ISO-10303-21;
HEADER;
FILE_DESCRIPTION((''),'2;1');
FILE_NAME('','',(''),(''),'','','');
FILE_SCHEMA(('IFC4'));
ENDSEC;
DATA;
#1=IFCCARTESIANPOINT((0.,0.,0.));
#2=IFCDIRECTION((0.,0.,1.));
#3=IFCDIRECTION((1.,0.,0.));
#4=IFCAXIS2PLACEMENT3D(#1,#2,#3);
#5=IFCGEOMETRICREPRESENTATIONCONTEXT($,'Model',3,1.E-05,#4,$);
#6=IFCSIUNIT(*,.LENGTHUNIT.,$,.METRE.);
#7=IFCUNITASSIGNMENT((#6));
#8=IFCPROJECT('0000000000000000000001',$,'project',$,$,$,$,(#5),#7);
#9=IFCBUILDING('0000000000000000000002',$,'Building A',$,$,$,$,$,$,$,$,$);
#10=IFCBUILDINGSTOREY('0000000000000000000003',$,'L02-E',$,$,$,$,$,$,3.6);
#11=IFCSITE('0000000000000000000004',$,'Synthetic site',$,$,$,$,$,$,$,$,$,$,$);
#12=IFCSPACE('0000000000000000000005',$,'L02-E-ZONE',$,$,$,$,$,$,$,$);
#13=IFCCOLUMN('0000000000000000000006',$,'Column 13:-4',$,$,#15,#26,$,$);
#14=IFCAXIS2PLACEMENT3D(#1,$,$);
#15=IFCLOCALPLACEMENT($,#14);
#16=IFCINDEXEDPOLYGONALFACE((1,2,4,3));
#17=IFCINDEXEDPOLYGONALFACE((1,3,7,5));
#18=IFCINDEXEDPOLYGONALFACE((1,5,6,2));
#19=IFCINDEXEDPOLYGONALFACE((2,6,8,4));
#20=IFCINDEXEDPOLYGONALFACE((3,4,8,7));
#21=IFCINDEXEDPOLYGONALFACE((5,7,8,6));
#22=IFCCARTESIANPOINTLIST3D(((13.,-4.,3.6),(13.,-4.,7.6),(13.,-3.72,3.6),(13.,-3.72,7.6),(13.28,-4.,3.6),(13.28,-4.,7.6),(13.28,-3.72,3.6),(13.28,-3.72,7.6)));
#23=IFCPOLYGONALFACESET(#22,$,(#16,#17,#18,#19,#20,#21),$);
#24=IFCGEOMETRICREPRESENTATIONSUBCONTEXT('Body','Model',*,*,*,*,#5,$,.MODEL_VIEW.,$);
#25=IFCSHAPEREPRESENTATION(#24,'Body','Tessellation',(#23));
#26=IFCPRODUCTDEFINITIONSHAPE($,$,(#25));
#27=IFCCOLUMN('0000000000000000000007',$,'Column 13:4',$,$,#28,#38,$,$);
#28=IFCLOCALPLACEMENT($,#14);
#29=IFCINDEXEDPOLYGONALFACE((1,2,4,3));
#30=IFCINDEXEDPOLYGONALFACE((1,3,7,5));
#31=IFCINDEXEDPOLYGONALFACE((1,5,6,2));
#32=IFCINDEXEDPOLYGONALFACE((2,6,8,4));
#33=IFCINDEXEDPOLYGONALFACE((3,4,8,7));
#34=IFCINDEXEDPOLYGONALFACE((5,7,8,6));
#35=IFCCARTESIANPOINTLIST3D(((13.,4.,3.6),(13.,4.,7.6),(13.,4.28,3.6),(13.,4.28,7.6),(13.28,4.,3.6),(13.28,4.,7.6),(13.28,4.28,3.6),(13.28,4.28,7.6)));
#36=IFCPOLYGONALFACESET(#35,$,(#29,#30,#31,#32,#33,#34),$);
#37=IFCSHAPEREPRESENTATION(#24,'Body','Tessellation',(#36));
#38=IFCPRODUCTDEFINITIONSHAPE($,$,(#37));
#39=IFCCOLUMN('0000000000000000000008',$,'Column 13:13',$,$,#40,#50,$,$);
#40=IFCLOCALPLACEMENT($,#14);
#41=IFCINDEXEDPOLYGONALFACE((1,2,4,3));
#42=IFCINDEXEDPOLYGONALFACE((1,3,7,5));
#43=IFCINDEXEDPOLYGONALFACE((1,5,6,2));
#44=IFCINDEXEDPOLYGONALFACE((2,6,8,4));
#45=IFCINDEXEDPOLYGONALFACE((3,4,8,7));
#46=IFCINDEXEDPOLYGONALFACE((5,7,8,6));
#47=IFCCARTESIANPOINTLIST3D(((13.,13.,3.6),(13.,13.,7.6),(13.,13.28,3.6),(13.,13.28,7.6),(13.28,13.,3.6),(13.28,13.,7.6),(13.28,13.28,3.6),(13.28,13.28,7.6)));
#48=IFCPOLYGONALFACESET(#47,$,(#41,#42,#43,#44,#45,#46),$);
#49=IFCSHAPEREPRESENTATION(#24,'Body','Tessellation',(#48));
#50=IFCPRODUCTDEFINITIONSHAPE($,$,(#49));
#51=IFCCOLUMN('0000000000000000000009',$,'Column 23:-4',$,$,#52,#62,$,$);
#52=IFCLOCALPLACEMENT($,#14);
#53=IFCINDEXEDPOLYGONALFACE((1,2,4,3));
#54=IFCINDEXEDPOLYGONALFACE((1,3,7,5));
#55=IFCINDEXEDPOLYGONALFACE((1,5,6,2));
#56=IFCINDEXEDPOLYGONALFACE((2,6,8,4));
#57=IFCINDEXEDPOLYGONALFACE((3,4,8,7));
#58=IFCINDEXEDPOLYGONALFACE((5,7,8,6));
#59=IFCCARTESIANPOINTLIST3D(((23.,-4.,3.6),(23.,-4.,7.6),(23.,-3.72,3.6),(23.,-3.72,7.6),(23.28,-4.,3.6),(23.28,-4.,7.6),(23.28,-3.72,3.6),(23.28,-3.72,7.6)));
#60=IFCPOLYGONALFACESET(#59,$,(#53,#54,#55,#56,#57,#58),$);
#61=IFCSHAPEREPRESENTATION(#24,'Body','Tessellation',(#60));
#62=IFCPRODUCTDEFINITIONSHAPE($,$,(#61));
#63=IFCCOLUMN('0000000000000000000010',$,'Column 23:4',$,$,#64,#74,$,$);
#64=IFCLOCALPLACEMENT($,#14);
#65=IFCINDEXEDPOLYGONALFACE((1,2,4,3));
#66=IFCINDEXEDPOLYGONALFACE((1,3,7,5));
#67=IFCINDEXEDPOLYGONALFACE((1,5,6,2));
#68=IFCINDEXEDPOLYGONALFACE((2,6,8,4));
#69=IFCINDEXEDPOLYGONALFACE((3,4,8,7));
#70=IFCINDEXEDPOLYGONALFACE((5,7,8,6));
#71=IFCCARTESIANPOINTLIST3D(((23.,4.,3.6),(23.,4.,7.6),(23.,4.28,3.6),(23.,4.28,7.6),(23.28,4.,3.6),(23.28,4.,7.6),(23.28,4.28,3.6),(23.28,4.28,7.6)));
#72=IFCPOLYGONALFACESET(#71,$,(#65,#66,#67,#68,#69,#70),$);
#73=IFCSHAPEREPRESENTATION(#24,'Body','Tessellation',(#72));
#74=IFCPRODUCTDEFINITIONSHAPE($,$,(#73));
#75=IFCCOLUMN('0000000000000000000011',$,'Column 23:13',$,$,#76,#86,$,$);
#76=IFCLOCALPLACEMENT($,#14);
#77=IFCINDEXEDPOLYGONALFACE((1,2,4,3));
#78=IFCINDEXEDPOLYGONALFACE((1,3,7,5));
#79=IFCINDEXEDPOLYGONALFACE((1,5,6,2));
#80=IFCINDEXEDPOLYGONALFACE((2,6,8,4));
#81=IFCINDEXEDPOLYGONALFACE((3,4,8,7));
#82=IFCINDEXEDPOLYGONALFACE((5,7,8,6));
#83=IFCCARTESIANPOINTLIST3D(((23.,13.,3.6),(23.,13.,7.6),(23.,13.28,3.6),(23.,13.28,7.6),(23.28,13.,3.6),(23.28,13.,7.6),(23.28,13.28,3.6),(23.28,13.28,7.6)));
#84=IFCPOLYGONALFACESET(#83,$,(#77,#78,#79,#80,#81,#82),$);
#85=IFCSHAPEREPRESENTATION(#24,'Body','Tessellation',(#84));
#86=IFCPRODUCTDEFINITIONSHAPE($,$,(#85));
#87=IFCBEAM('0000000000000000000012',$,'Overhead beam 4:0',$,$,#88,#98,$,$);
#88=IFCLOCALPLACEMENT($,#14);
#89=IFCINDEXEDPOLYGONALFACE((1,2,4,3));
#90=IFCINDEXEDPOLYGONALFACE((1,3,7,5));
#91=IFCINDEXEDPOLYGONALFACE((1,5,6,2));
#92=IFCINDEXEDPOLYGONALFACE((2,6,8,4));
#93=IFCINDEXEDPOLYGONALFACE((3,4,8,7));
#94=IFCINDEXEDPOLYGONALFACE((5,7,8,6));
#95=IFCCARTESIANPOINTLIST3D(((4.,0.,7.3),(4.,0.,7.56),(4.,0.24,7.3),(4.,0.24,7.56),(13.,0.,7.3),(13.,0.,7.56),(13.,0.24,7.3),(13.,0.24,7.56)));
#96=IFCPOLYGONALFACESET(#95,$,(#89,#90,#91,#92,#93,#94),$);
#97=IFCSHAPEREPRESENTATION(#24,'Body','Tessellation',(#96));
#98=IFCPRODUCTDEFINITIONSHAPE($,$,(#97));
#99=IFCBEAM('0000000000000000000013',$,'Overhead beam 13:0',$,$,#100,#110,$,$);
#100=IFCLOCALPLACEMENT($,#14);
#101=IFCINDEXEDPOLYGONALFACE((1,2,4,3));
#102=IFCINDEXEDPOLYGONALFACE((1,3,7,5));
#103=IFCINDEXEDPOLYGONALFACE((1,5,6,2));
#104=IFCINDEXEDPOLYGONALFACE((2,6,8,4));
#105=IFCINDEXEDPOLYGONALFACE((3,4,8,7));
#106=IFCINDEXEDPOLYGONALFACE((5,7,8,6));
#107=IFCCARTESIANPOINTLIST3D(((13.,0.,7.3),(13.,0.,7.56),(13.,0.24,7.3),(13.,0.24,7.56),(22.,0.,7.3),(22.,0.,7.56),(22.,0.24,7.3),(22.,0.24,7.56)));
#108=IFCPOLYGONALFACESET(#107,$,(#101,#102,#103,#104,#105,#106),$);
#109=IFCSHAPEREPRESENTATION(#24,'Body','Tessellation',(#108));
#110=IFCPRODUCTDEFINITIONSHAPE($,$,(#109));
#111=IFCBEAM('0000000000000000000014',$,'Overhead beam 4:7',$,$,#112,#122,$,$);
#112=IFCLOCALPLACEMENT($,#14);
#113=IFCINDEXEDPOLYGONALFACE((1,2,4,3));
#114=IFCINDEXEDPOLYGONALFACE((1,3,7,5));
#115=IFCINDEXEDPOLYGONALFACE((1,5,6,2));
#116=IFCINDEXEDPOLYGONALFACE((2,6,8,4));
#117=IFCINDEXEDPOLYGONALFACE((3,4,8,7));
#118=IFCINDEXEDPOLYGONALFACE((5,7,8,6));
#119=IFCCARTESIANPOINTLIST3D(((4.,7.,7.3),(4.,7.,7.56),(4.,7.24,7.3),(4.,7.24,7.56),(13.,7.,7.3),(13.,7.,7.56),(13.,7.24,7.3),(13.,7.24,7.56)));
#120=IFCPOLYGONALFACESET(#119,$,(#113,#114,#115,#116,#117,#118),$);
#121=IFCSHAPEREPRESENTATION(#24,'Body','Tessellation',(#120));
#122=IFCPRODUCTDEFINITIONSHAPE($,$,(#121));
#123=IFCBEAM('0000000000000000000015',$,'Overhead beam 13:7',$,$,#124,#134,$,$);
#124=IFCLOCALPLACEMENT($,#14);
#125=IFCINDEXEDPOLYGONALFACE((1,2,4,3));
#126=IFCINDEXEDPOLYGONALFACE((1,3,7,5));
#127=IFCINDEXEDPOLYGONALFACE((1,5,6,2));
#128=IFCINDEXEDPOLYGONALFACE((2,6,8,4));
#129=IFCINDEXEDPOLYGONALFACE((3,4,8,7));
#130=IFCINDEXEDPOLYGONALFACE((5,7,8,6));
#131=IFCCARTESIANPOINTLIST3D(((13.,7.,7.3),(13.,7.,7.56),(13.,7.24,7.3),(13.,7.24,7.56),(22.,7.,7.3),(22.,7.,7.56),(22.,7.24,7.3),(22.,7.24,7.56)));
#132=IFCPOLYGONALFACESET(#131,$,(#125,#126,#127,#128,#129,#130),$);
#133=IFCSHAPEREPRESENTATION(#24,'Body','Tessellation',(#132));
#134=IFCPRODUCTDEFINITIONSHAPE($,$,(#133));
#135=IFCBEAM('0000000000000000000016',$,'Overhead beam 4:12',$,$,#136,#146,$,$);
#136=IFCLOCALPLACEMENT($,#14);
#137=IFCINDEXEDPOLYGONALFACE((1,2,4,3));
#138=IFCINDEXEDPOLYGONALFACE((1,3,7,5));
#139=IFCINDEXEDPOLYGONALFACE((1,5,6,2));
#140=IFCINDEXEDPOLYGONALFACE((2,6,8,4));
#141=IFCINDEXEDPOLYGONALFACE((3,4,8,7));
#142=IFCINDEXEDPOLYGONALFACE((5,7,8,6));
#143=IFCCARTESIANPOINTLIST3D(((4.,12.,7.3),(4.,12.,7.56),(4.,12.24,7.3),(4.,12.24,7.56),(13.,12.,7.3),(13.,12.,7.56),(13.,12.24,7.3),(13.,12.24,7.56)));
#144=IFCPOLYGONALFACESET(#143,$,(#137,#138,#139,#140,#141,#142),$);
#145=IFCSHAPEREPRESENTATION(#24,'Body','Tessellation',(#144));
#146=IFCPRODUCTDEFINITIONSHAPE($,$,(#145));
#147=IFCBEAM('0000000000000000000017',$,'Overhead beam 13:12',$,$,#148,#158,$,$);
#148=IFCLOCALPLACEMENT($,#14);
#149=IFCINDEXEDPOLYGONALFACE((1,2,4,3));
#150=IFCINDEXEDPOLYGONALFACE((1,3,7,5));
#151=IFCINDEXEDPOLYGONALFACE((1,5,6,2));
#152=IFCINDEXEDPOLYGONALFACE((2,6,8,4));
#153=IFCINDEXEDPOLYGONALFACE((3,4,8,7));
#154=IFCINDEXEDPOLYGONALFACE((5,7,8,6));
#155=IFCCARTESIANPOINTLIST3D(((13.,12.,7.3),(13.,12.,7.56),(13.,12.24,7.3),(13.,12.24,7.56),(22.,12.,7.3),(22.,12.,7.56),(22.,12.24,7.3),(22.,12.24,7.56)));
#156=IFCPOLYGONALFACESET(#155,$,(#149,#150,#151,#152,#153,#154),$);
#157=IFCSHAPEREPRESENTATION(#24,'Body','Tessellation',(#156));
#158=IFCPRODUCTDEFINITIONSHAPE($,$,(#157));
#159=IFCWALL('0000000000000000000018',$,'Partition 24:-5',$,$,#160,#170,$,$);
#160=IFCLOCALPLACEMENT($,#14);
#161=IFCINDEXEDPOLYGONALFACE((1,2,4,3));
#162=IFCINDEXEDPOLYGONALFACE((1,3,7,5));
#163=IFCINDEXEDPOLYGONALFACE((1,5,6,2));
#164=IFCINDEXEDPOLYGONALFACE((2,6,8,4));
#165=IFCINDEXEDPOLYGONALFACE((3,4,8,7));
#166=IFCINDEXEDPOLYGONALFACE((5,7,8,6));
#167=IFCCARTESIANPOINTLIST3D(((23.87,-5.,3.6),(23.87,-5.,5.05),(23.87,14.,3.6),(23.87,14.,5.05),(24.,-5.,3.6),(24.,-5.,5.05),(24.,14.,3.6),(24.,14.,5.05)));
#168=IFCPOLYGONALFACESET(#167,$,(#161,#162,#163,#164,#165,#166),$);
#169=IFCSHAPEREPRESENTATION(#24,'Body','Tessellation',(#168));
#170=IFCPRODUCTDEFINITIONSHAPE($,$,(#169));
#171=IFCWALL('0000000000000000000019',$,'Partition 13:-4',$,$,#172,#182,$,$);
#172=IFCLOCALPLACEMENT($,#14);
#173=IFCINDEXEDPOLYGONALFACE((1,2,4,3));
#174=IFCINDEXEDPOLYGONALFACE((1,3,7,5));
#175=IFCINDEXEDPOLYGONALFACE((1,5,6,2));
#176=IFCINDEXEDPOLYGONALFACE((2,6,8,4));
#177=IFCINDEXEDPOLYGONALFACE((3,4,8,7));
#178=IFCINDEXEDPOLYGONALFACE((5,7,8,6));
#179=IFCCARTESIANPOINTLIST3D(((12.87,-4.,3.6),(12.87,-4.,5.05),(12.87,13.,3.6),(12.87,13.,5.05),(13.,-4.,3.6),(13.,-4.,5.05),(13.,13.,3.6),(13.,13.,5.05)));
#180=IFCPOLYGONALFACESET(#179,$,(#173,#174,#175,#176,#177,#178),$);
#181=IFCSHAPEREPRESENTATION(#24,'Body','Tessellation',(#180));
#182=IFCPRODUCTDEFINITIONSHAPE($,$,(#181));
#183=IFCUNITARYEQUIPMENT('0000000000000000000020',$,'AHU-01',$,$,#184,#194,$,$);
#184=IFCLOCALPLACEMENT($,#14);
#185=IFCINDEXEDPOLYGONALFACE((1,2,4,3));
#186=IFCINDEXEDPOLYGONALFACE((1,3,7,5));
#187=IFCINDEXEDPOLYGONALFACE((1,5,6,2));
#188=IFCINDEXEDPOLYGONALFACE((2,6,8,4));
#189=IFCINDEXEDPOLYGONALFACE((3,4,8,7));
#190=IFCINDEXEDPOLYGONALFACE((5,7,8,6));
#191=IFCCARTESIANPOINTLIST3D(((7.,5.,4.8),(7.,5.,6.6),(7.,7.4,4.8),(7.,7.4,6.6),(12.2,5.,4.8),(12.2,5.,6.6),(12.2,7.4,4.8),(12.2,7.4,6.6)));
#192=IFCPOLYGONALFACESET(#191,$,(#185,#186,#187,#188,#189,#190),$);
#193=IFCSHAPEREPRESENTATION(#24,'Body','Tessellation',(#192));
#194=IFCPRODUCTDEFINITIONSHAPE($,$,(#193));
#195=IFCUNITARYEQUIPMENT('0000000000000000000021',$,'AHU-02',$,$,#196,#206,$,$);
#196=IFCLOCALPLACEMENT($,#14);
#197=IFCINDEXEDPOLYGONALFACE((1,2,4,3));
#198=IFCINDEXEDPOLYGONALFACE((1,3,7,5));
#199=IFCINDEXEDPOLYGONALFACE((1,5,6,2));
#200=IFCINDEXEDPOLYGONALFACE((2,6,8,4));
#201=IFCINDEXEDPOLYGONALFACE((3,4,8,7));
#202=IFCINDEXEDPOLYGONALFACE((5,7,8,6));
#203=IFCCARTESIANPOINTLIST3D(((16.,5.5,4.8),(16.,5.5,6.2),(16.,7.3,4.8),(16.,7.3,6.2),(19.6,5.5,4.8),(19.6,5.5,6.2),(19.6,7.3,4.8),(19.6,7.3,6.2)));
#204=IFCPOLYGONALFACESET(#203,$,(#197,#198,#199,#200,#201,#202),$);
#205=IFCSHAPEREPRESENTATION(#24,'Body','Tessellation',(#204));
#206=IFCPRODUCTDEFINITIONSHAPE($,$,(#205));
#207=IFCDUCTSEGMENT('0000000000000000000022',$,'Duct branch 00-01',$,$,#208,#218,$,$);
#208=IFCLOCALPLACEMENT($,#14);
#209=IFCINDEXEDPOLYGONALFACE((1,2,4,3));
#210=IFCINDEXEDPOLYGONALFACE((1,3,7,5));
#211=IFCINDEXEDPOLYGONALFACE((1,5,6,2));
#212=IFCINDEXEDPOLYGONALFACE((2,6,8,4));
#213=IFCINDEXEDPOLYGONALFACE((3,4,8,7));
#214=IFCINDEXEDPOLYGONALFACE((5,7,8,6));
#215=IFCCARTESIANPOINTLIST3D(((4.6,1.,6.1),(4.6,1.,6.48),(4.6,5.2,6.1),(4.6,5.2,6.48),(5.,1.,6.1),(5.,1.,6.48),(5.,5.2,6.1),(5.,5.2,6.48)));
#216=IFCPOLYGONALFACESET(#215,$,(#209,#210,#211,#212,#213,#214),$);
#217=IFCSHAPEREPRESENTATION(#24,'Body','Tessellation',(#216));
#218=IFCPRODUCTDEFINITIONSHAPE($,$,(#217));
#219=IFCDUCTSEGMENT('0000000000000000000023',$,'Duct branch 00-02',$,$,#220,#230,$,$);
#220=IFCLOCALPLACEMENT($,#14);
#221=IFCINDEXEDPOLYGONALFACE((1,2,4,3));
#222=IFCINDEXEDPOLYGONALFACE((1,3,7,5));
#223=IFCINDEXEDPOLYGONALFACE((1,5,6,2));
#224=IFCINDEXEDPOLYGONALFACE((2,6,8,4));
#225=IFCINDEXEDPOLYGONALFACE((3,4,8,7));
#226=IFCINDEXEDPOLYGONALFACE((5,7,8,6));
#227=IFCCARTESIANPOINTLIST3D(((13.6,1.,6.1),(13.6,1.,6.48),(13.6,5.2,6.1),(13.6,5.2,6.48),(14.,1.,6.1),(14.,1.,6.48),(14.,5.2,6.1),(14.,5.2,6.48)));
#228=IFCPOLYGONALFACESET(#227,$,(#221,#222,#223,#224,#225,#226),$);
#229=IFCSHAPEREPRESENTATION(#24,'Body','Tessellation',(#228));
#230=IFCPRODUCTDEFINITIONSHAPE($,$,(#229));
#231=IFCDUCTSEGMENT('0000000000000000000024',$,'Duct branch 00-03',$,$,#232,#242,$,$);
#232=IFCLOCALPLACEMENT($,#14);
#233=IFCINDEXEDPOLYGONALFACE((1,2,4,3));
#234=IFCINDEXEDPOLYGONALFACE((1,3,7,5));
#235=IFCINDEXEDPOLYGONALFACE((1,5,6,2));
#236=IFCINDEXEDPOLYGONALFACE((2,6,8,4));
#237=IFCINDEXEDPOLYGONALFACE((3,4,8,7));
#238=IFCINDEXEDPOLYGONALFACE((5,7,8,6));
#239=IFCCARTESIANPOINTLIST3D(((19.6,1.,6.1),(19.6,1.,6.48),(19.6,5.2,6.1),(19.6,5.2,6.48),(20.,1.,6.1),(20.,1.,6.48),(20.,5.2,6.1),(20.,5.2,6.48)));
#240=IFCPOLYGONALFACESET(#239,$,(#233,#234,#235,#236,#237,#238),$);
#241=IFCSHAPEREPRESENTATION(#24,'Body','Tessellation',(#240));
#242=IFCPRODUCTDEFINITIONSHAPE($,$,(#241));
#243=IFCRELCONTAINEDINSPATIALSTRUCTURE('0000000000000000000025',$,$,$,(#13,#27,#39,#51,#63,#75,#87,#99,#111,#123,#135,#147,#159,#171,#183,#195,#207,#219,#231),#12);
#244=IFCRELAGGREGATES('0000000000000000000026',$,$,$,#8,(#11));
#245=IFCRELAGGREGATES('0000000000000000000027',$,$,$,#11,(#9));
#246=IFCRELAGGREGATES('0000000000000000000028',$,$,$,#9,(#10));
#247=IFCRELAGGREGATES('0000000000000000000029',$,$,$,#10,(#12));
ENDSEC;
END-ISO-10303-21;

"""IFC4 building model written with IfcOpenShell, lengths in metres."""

from ifc_helpers import new_model, si_unit, frame, origin_with_axes, place, context, subcontext, project, spatial, indexed_curve, outline, extrude, element, save


model = new_model("IFC4")

# Units and contexts
model_context = context("Model", 3, precision=1e-05, world=origin_with_axes())
body_context = subcontext(model_context, "Body", "Model", "MODEL_VIEW")
ifc_project = project(units=[si_unit("LENGTHUNIT", "METRE")], contexts=[model_context])

# Site, building, storey, space
site = spatial("IfcSite", under=ifc_project, Name="Synthetic site")
building = spatial("IfcBuilding", under=site, Name="Building A")
storey = spatial("IfcBuildingStorey", under=building, Name="L02-E", Elevation=3.6)
space = spatial("IfcSpace", under=storey, Name="L02-E-ZONE")

# Columns
for number, where, z_axis, x_axis, name in (
    (1, (13.0, -4.0, 3.6), (0.0, 0.0, 1.0), (1.0, 0.0, 0.0), "Column 13:-4"),
    (2, (13.0, 4.0, 3.6), (0.0, 0.0, 1.0), (1.0, 0.0, 0.0), "Column 13:4"),
    (3, (13.0, 13.0, 3.6), (0.0, 0.0, 1.0), (1.0, 0.0, 0.0), "Column 13:13"),
    (4, (23.0, -4.0, 3.6), (0.0, 0.0, 1.0), (1.0, 0.0, 0.0), "Column 23:-4"),
    (5, (23.0, 4.0, 3.6), (0.0, 0.0, 1.0), (1.0, 0.0, 0.0), "Column 23:4"),
    (6, (23.0, 13.0, 3.6), (0.0, 0.0, 1.0), (1.0, 0.0, 0.0), "Column 23:13"),
):
    element("IfcColumn", number, at=place(None, frame(where, z_axis=z_axis, x_axis=x_axis)), inside=space, Name=name, context=body_context, shape_type="SweptSolid", body=[
        extrude(outline(indexed_curve([(0.0, 0.0), (0.0, 0.28), (0.28, 0.28), (0.28, 0.0), (0.0, 0.0)], self_intersect=False)), origin_with_axes(), (0.0, 0.0, 1.0), 4.0),
    ])

# Beams
for number, where, z_axis, x_axis, name in (
    (7, (4.0, 0.0, 7.3), (0.0, 0.0, 1.0), (1.0, 0.0, 0.0), "Overhead beam 4:0"),
    (8, (13.0, 0.0, 7.3), (0.0, 0.0, 1.0), (1.0, 0.0, 0.0), "Overhead beam 13:0"),
    (9, (4.0, 7.0, 7.3), (0.0, 0.0, 1.0), (1.0, 0.0, 0.0), "Overhead beam 4:7"),
    (10, (13.0, 7.0, 7.3), (0.0, 0.0, 1.0), (1.0, 0.0, 0.0), "Overhead beam 13:7"),
    (11, (4.0, 12.0, 7.3), (0.0, 0.0, 1.0), (1.0, 0.0, 0.0), "Overhead beam 4:12"),
    (12, (13.0, 12.0, 7.3), (0.0, 0.0, 1.0), (1.0, 0.0, 0.0), "Overhead beam 13:12"),
):
    element("IfcBeam", number, at=place(None, frame(where, z_axis=z_axis, x_axis=x_axis)), inside=space, Name=name, context=body_context, shape_type="SweptSolid", body=[
        extrude(outline(indexed_curve([(0.0, 0.0), (0.0, 0.24), (9.0, 0.24), (9.0, 0.0), (0.0, 0.0)], self_intersect=False)), origin_with_axes(), (0.0, 0.0, 1.0), 0.26),
    ])

# Walls
wall_1_placement = place(None, frame((24.0, -5.0, 3.6), z_axis=(0.0, 0.0, 1.0), x_axis=(0.0, 1.0, 0.0)))
element("IfcWall", 13, at=wall_1_placement, inside=space, Name="Partition 24:-5", context=body_context, shape_type="SweptSolid", body=[
    extrude(outline(indexed_curve([(0.0, 0.0), (0.0, 0.13), (19.0, 0.13), (19.0, 0.0), (0.0, 0.0)], self_intersect=False)), origin_with_axes(), (0.0, 0.0, 1.0), 1.45),
])
wall_2_placement = place(None, frame((13.0, -4.0, 3.6), z_axis=(0.0, 0.0, 1.0), x_axis=(0.0, 1.0, 0.0)))
element("IfcWall", 14, at=wall_2_placement, inside=space, Name="Partition 13:-4", context=body_context, shape_type="SweptSolid", body=[
    extrude(outline(indexed_curve([(0.0, 0.0), (0.0, 0.13), (17.0, 0.13), (17.0, 0.0), (0.0, 0.0)], self_intersect=False)), origin_with_axes(), (0.0, 0.0, 1.0), 1.45),
])

# Unitary equipment
unitary_equipment_1_placement = place(None, frame((7.0, 5.0, 4.8), z_axis=(0.0, 0.0, 1.0), x_axis=(1.0, 0.0, 0.0)))
element("IfcUnitaryEquipment", 15, at=unitary_equipment_1_placement, inside=space, Name="AHU-01", context=body_context, shape_type="SweptSolid", body=[
    extrude(outline(indexed_curve([(0.0, 0.0), (0.0, 2.4), (5.2, 2.4), (5.2, 0.0), (0.0, 0.0)], self_intersect=False)), origin_with_axes(), (0.0, 0.0, 1.0), 1.8),
])
unitary_equipment_2_placement = place(None, frame((16.0, 5.5, 4.8), z_axis=(0.0, 0.0, 1.0), x_axis=(1.0, 0.0, 0.0)))
element("IfcUnitaryEquipment", 16, at=unitary_equipment_2_placement, inside=space, Name="AHU-02", context=body_context, shape_type="SweptSolid", body=[
    extrude(outline(indexed_curve([(0.0, 0.0), (0.0, 1.8), (3.6, 1.8), (3.6, 0.0), (0.0, 0.0)], self_intersect=False)), origin_with_axes(), (0.0, 0.0, 1.0), 1.4),
])

# Duct segments
for number, where, z_axis, x_axis, name in (
    (17, (5.0, 1.0, 6.1), (0.0, 0.0, 1.0), (0.0, 1.0, 0.0), "Duct branch 00-01"),
    (18, (14.0, 1.0, 6.1), (0.0, 0.0, 1.0), (0.0, 1.0, 0.0), "Duct branch 00-02"),
    (19, (20.0, 1.0, 6.1), (0.0, 0.0, 1.0), (0.0, 1.0, 0.0), "Duct branch 00-03"),
):
    element("IfcDuctSegment", number, at=place(None, frame(where, z_axis=z_axis, x_axis=x_axis)), inside=space, Name=name, context=body_context, shape_type="SweptSolid", body=[
        extrude(outline(indexed_curve([(0.0, 0.0), (0.0, 0.4), (4.2, 0.4), (4.2, 0.0), (0.0, 0.0)], self_intersect=False)), origin_with_axes(), (0.0, 0.0, 1.0), 0.38),
    ])

save(model, "model.ifc")
